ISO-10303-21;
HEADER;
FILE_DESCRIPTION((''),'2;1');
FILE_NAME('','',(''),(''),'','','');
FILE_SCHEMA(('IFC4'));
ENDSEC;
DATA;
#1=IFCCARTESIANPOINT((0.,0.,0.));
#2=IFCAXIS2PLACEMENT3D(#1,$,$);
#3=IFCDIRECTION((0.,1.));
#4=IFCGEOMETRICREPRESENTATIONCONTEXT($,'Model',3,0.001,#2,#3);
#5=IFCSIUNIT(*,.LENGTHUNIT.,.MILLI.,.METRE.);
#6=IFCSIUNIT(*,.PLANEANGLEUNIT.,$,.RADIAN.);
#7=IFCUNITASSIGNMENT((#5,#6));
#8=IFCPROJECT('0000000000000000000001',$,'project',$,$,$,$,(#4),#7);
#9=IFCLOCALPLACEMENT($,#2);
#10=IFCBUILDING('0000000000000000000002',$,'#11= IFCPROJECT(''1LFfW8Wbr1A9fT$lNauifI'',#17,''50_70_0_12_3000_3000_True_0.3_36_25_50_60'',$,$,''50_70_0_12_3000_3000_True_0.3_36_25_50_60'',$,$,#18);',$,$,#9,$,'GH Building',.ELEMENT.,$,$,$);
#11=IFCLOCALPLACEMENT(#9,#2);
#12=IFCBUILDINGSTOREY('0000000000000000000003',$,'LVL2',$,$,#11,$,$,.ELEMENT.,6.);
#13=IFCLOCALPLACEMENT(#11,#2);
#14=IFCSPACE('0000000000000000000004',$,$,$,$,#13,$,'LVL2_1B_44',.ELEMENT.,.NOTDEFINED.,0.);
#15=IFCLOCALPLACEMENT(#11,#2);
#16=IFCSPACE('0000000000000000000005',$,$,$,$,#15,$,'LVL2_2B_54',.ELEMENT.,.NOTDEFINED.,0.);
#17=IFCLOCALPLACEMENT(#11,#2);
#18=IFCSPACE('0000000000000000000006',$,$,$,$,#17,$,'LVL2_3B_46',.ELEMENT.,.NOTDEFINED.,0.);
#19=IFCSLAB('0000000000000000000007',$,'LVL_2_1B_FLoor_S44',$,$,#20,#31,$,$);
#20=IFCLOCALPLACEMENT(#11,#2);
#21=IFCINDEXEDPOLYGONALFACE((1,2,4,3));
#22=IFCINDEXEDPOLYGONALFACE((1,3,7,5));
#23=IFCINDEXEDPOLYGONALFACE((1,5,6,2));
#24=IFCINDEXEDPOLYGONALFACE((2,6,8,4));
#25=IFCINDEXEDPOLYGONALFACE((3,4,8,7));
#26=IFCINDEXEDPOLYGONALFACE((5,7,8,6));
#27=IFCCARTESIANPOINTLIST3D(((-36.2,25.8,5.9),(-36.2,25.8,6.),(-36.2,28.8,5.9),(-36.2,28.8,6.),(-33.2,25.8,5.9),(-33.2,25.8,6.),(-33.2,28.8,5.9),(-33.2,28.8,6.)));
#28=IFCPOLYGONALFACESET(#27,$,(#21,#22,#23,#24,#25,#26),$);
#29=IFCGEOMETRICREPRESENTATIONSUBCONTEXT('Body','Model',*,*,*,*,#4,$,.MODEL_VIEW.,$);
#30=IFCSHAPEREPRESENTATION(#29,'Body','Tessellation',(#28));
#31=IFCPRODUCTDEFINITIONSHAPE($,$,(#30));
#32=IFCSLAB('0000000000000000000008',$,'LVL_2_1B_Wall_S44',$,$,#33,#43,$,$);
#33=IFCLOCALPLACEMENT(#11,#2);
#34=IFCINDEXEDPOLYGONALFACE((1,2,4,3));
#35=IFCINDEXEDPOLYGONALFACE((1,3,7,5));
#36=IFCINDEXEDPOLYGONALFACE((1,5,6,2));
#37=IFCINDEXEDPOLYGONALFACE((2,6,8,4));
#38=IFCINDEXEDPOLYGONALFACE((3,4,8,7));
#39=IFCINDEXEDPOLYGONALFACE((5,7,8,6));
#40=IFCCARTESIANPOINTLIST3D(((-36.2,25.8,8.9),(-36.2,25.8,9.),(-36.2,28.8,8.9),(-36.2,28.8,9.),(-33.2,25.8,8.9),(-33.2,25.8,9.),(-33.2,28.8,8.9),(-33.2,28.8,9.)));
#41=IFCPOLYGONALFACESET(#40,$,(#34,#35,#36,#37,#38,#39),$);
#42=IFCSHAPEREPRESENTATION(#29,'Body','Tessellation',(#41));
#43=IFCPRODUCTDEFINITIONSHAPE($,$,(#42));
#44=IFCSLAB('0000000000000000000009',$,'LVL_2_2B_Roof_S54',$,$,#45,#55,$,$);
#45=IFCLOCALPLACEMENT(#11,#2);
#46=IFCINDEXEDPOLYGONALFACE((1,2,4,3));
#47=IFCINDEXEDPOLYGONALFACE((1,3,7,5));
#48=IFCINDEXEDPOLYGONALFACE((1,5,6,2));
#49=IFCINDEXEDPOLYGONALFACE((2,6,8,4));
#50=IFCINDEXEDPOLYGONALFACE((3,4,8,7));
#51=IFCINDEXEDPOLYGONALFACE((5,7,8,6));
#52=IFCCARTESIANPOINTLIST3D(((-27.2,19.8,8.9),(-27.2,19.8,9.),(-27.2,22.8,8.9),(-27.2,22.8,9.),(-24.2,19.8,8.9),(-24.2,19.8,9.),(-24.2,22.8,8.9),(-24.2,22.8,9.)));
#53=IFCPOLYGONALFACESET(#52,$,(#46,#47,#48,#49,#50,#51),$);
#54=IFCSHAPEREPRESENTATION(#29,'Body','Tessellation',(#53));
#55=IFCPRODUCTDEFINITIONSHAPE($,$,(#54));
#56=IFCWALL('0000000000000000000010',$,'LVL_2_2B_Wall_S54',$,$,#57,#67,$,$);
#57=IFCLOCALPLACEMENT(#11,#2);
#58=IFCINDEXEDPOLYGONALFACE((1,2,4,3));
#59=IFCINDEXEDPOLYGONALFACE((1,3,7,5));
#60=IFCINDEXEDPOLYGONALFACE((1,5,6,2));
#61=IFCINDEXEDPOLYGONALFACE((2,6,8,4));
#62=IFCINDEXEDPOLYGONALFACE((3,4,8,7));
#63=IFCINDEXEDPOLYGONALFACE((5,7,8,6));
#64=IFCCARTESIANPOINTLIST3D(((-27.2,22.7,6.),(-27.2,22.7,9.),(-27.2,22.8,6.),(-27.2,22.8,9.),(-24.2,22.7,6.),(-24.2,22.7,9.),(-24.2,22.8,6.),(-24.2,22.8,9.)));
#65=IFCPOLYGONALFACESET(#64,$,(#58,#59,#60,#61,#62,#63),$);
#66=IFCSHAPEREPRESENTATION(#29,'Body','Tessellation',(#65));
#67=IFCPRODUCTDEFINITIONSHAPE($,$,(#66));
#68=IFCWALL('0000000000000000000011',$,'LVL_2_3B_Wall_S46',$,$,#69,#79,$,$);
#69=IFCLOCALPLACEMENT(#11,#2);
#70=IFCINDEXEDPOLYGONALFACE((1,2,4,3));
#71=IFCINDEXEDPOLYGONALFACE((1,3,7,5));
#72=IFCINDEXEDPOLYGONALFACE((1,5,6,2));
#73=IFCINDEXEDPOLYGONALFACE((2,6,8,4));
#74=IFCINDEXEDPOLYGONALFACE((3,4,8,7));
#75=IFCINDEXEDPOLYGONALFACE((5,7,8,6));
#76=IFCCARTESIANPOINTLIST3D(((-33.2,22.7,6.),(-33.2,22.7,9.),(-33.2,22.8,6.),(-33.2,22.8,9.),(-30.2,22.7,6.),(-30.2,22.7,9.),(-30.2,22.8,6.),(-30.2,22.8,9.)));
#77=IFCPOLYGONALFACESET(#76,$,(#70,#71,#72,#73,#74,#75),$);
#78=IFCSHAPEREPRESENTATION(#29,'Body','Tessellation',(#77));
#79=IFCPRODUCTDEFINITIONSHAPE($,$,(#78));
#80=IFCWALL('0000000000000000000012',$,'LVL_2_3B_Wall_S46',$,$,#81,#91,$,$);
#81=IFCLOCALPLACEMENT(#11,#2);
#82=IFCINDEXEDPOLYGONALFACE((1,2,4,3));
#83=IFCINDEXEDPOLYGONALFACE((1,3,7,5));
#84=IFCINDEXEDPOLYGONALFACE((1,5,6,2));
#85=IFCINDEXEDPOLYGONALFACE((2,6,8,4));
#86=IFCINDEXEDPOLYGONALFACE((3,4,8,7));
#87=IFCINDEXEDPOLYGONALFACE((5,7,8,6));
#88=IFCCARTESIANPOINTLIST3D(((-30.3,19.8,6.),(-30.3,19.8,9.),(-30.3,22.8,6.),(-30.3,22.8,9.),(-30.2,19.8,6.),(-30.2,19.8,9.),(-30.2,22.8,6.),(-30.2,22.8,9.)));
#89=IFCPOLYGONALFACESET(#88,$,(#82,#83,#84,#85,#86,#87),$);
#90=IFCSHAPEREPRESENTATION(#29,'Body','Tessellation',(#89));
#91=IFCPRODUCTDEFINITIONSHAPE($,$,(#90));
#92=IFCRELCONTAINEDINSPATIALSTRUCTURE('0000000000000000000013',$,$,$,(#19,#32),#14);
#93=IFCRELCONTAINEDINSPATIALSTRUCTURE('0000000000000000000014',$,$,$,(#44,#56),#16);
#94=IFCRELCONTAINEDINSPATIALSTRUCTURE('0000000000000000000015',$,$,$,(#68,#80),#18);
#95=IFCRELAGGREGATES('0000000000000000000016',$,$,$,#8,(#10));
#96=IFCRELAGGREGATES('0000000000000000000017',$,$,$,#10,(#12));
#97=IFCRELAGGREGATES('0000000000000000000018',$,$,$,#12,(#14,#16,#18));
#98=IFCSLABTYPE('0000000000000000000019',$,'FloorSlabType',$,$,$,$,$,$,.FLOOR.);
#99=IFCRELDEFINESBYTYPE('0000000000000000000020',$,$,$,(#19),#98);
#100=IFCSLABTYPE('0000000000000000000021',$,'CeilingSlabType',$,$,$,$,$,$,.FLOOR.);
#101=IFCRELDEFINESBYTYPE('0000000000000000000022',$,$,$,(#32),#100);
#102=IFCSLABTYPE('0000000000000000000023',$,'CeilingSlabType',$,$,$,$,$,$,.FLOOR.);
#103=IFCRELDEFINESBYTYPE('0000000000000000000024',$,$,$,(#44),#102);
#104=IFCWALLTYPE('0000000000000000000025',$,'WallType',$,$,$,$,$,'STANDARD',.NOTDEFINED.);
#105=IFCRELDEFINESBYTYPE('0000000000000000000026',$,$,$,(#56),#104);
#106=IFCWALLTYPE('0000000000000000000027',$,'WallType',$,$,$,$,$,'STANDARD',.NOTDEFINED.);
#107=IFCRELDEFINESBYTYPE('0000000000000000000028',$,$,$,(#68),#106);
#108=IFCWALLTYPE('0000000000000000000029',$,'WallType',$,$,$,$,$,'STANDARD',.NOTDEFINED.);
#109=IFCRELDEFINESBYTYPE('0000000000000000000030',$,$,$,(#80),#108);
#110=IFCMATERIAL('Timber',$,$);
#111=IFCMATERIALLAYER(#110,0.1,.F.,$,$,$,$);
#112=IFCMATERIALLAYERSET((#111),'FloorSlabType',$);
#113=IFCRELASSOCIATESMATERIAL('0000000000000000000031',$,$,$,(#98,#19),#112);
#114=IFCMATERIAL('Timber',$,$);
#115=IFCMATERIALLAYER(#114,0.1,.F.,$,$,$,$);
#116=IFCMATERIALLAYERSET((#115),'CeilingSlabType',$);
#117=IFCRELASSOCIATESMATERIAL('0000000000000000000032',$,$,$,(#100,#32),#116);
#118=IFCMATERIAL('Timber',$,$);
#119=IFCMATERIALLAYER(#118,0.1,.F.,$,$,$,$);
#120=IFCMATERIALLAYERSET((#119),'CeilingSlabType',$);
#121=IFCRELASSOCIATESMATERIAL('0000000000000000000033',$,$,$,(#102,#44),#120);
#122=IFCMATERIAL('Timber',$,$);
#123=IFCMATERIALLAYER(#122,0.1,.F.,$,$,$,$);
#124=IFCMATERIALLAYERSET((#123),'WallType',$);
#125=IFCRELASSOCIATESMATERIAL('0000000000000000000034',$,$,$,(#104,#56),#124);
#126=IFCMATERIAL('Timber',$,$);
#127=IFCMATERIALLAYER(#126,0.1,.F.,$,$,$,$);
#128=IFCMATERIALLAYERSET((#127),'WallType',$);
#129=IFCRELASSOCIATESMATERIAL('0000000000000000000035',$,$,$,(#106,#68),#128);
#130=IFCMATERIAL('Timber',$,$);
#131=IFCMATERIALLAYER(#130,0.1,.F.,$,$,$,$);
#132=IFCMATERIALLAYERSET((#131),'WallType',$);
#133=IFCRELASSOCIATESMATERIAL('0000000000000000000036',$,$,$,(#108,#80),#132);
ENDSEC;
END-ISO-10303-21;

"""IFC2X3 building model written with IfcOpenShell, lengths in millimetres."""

from ifc_helpers import new_model, si_unit, direction, frame, frame_2d, origin, place, context, subcontext, project, spatial, rectangle, extrude, material, layer, layer_set, layer_usage, type_object, element, save


model = new_model("IFC2X3")

# Units and contexts
model_context = context("Model", 3, precision=0.001, world=origin(), true_north=direction((0.0, 1.0)))
body_context = subcontext(model_context, "Body", "Model", "MODEL_VIEW")
ifc_project = project(units=[si_unit("LENGTHUNIT", "METRE", prefix="MILLI"), si_unit("PLANEANGLEUNIT", "RADIAN")], contexts=[model_context])

# Building, storey
building_placement = place(None, origin())
building = spatial("IfcBuilding", under=ifc_project, at=building_placement, Name="#11= IFCPROJECT('1LFfW8Wbr1A9fT$lNauifI',#17,'50_70_0_12_3000_3000_True_0.3_36_25_50_60',$,$,'50_70_0_12_3000_3000_True_0.3_36_25_50_60',$,$,#18);", LongName="GH Building", CompositionType="ELEMENT")
storey_placement = place(building_placement, origin())
storey = spatial("IfcBuildingStorey", under=building, at=storey_placement, Name="LVL2", CompositionType="ELEMENT", Elevation=6.0)

# Shared definitions
space_1_placement = place(storey_placement, origin())
space_1 = spatial("IfcSpace", under=storey, at=space_1_placement, LongName="LVL2_1B_44", CompositionType="ELEMENT", InteriorOrExteriorSpace="NOTDEFINED", ElevationWithFlooring=0.0)

# Slabs
ifc_material_1 = material(Name="Timber")
ifc_layer_1 = layer(ifc_material_1, 0.1, ventilated=False)
ifc_layer_set_1 = layer_set([ifc_layer_1], Name="FloorSlabType")
ifc_layer_usage_1 = layer_usage(ifc_layer_set_1, "AXIS3", "NEGATIVE", -0.1)
slab_type_1 = type_object("IfcSlabType", Name="FloorSlabType", PredefinedType="FLOOR", material=ifc_layer_set_1)
slab_1_placement = place(space_1_placement, frame((-33.2, 25.8, 5.9), z_axis=(0.0, 0.0, 1.0), x_axis=(0.0, 1.0, 0.0)))
element("IfcSlab", 1, at=slab_1_placement, inside=space_1, type_object=slab_type_1, material=ifc_layer_usage_1, Name="LVL_2_1B_FLoor_S44", context=body_context, shape_type="SweptSolid", body=[
    extrude(rectangle(XDim=3.0, YDim=3.0, at=frame_2d((1.5, 1.5))), origin(), (0.0, 0.0, 1.0), 0.1),
])
ifc_material_2 = material(Name="Timber")
ifc_layer_2 = layer(ifc_material_2, 0.1, ventilated=False)
ifc_layer_set_2 = layer_set([ifc_layer_2], Name="CeilingSlabType")
ifc_layer_usage_2 = layer_usage(ifc_layer_set_2, "AXIS3", "NEGATIVE", -0.1)
slab_type_2 = type_object("IfcSlabType", Name="CeilingSlabType", PredefinedType="FLOOR", material=ifc_layer_set_2)
slab_2_placement = place(space_1_placement, frame((-33.2, 25.8, 8.9), z_axis=(0.0, 0.0, 1.0), x_axis=(0.0, 1.0, 0.0)))
element("IfcSlab", 2, at=slab_2_placement, inside=space_1, type_object=slab_type_2, material=ifc_layer_usage_2, Name="LVL_2_1B_Wall_S44", context=body_context, shape_type="SweptSolid", body=[
    extrude(rectangle(XDim=3.0, YDim=3.0, at=frame_2d((1.5, 1.5))), origin(), (0.0, 0.0, 1.0), 0.1),
])

# Shared definitions
space_2_placement = place(storey_placement, origin())
space_2 = spatial("IfcSpace", under=storey, at=space_2_placement, LongName="LVL2_2B_54", CompositionType="ELEMENT", InteriorOrExteriorSpace="NOTDEFINED", ElevationWithFlooring=0.0)

# Slab
ifc_material_3 = material(Name="Timber")
ifc_layer_3 = layer(ifc_material_3, 0.1, ventilated=False)
ifc_layer_set_3 = layer_set([ifc_layer_3], Name="CeilingSlabType")
ifc_layer_usage_3 = layer_usage(ifc_layer_set_3, "AXIS3", "NEGATIVE", -0.1)
slab_type_3 = type_object("IfcSlabType", Name="CeilingSlabType", PredefinedType="FLOOR", material=ifc_layer_set_3)
slab_3_placement = place(space_2_placement, frame((-27.2, 19.8, 8.9)))
element("IfcSlab", 3, at=slab_3_placement, inside=space_2, type_object=slab_type_3, material=ifc_layer_usage_3, Name="LVL_2_2B_Roof_S54", context=body_context, shape_type="SweptSolid", body=[
    extrude(rectangle(XDim=3.0, YDim=3.0, at=frame_2d((1.5, 1.5))), origin(), (0.0, 0.0, 1.0), 0.1),
])

# Wall
ifc_material_4 = material(Name="Timber")
ifc_layer_4 = layer(ifc_material_4, 0.1, ventilated=False)
ifc_layer_set_4 = layer_set([ifc_layer_4], Name="WallType")
ifc_layer_usage_4 = layer_usage(ifc_layer_set_4, "AXIS2", "NEGATIVE", 0.0)
wall_type_1 = type_object("IfcWallType", Name="WallType", ElementType="STANDARD", PredefinedType="NOTDEFINED", material=ifc_layer_set_4)
wall_1_placement = place(space_2_placement, frame((-27.2, 22.8, 6.0)))
element("IfcWall", 4, at=wall_1_placement, inside=space_2, type_object=wall_type_1, material=ifc_layer_usage_4, Name="LVL_2_2B_Wall_S54", context=body_context, shape_type="SweptSolid", body=[
    extrude(rectangle(XDim=3.0, YDim=0.1, at=frame_2d((1.5, -0.1))), origin(), (0.0, 0.0, 1.0), 3.0),
])

# Shared definitions
space_3_placement = place(storey_placement, origin())
space_3 = spatial("IfcSpace", under=storey, at=space_3_placement, LongName="LVL2_3B_46", CompositionType="ELEMENT", InteriorOrExteriorSpace="NOTDEFINED", ElevationWithFlooring=0.0)

# Walls
ifc_material_5 = material(Name="Timber")
ifc_layer_5 = layer(ifc_material_5, 0.1, ventilated=False)
ifc_layer_set_5 = layer_set([ifc_layer_5], Name="WallType")
ifc_layer_usage_5 = layer_usage(ifc_layer_set_5, "AXIS2", "NEGATIVE", 0.0)
wall_type_2 = type_object("IfcWallType", Name="WallType", ElementType="STANDARD", PredefinedType="NOTDEFINED", material=ifc_layer_set_5)
wall_2_placement = place(space_3_placement, frame((-33.2, 22.8, 6.0)))
element("IfcWall", 5, at=wall_2_placement, inside=space_3, type_object=wall_type_2, material=ifc_layer_usage_5, Name="LVL_2_3B_Wall_S46", context=body_context, shape_type="SweptSolid", body=[
    extrude(rectangle(XDim=3.0, YDim=0.1, at=frame_2d((1.5, -0.1))), origin(), (0.0, 0.0, 1.0), 3.0),
])
ifc_material_6 = material(Name="Timber")
ifc_layer_6 = layer(ifc_material_6, 0.1, ventilated=False)
ifc_layer_set_6 = layer_set([ifc_layer_6], Name="WallType")
ifc_layer_usage_6 = layer_usage(ifc_layer_set_6, "AXIS2", "NEGATIVE", 0.0)
wall_type_3 = type_object("IfcWallType", Name="WallType", ElementType="STANDARD", PredefinedType="NOTDEFINED", material=ifc_layer_set_6)
wall_3_placement = place(space_3_placement, frame((-30.2, 22.8, 6.0), z_axis=(0.0, 0.0, 1.0), x_axis=(0.0, -1.0, 0.0)))
element("IfcWall", 6, at=wall_3_placement, inside=space_3, type_object=wall_type_3, material=ifc_layer_usage_6, Name="LVL_2_3B_Wall_S46", context=body_context, shape_type="SweptSolid", body=[
    extrude(rectangle(XDim=3.0, YDim=0.1, at=frame_2d((1.5, -0.1))), origin(), (0.0, 0.0, 1.0), 3.0),
])

save(model, "model.ifc")
